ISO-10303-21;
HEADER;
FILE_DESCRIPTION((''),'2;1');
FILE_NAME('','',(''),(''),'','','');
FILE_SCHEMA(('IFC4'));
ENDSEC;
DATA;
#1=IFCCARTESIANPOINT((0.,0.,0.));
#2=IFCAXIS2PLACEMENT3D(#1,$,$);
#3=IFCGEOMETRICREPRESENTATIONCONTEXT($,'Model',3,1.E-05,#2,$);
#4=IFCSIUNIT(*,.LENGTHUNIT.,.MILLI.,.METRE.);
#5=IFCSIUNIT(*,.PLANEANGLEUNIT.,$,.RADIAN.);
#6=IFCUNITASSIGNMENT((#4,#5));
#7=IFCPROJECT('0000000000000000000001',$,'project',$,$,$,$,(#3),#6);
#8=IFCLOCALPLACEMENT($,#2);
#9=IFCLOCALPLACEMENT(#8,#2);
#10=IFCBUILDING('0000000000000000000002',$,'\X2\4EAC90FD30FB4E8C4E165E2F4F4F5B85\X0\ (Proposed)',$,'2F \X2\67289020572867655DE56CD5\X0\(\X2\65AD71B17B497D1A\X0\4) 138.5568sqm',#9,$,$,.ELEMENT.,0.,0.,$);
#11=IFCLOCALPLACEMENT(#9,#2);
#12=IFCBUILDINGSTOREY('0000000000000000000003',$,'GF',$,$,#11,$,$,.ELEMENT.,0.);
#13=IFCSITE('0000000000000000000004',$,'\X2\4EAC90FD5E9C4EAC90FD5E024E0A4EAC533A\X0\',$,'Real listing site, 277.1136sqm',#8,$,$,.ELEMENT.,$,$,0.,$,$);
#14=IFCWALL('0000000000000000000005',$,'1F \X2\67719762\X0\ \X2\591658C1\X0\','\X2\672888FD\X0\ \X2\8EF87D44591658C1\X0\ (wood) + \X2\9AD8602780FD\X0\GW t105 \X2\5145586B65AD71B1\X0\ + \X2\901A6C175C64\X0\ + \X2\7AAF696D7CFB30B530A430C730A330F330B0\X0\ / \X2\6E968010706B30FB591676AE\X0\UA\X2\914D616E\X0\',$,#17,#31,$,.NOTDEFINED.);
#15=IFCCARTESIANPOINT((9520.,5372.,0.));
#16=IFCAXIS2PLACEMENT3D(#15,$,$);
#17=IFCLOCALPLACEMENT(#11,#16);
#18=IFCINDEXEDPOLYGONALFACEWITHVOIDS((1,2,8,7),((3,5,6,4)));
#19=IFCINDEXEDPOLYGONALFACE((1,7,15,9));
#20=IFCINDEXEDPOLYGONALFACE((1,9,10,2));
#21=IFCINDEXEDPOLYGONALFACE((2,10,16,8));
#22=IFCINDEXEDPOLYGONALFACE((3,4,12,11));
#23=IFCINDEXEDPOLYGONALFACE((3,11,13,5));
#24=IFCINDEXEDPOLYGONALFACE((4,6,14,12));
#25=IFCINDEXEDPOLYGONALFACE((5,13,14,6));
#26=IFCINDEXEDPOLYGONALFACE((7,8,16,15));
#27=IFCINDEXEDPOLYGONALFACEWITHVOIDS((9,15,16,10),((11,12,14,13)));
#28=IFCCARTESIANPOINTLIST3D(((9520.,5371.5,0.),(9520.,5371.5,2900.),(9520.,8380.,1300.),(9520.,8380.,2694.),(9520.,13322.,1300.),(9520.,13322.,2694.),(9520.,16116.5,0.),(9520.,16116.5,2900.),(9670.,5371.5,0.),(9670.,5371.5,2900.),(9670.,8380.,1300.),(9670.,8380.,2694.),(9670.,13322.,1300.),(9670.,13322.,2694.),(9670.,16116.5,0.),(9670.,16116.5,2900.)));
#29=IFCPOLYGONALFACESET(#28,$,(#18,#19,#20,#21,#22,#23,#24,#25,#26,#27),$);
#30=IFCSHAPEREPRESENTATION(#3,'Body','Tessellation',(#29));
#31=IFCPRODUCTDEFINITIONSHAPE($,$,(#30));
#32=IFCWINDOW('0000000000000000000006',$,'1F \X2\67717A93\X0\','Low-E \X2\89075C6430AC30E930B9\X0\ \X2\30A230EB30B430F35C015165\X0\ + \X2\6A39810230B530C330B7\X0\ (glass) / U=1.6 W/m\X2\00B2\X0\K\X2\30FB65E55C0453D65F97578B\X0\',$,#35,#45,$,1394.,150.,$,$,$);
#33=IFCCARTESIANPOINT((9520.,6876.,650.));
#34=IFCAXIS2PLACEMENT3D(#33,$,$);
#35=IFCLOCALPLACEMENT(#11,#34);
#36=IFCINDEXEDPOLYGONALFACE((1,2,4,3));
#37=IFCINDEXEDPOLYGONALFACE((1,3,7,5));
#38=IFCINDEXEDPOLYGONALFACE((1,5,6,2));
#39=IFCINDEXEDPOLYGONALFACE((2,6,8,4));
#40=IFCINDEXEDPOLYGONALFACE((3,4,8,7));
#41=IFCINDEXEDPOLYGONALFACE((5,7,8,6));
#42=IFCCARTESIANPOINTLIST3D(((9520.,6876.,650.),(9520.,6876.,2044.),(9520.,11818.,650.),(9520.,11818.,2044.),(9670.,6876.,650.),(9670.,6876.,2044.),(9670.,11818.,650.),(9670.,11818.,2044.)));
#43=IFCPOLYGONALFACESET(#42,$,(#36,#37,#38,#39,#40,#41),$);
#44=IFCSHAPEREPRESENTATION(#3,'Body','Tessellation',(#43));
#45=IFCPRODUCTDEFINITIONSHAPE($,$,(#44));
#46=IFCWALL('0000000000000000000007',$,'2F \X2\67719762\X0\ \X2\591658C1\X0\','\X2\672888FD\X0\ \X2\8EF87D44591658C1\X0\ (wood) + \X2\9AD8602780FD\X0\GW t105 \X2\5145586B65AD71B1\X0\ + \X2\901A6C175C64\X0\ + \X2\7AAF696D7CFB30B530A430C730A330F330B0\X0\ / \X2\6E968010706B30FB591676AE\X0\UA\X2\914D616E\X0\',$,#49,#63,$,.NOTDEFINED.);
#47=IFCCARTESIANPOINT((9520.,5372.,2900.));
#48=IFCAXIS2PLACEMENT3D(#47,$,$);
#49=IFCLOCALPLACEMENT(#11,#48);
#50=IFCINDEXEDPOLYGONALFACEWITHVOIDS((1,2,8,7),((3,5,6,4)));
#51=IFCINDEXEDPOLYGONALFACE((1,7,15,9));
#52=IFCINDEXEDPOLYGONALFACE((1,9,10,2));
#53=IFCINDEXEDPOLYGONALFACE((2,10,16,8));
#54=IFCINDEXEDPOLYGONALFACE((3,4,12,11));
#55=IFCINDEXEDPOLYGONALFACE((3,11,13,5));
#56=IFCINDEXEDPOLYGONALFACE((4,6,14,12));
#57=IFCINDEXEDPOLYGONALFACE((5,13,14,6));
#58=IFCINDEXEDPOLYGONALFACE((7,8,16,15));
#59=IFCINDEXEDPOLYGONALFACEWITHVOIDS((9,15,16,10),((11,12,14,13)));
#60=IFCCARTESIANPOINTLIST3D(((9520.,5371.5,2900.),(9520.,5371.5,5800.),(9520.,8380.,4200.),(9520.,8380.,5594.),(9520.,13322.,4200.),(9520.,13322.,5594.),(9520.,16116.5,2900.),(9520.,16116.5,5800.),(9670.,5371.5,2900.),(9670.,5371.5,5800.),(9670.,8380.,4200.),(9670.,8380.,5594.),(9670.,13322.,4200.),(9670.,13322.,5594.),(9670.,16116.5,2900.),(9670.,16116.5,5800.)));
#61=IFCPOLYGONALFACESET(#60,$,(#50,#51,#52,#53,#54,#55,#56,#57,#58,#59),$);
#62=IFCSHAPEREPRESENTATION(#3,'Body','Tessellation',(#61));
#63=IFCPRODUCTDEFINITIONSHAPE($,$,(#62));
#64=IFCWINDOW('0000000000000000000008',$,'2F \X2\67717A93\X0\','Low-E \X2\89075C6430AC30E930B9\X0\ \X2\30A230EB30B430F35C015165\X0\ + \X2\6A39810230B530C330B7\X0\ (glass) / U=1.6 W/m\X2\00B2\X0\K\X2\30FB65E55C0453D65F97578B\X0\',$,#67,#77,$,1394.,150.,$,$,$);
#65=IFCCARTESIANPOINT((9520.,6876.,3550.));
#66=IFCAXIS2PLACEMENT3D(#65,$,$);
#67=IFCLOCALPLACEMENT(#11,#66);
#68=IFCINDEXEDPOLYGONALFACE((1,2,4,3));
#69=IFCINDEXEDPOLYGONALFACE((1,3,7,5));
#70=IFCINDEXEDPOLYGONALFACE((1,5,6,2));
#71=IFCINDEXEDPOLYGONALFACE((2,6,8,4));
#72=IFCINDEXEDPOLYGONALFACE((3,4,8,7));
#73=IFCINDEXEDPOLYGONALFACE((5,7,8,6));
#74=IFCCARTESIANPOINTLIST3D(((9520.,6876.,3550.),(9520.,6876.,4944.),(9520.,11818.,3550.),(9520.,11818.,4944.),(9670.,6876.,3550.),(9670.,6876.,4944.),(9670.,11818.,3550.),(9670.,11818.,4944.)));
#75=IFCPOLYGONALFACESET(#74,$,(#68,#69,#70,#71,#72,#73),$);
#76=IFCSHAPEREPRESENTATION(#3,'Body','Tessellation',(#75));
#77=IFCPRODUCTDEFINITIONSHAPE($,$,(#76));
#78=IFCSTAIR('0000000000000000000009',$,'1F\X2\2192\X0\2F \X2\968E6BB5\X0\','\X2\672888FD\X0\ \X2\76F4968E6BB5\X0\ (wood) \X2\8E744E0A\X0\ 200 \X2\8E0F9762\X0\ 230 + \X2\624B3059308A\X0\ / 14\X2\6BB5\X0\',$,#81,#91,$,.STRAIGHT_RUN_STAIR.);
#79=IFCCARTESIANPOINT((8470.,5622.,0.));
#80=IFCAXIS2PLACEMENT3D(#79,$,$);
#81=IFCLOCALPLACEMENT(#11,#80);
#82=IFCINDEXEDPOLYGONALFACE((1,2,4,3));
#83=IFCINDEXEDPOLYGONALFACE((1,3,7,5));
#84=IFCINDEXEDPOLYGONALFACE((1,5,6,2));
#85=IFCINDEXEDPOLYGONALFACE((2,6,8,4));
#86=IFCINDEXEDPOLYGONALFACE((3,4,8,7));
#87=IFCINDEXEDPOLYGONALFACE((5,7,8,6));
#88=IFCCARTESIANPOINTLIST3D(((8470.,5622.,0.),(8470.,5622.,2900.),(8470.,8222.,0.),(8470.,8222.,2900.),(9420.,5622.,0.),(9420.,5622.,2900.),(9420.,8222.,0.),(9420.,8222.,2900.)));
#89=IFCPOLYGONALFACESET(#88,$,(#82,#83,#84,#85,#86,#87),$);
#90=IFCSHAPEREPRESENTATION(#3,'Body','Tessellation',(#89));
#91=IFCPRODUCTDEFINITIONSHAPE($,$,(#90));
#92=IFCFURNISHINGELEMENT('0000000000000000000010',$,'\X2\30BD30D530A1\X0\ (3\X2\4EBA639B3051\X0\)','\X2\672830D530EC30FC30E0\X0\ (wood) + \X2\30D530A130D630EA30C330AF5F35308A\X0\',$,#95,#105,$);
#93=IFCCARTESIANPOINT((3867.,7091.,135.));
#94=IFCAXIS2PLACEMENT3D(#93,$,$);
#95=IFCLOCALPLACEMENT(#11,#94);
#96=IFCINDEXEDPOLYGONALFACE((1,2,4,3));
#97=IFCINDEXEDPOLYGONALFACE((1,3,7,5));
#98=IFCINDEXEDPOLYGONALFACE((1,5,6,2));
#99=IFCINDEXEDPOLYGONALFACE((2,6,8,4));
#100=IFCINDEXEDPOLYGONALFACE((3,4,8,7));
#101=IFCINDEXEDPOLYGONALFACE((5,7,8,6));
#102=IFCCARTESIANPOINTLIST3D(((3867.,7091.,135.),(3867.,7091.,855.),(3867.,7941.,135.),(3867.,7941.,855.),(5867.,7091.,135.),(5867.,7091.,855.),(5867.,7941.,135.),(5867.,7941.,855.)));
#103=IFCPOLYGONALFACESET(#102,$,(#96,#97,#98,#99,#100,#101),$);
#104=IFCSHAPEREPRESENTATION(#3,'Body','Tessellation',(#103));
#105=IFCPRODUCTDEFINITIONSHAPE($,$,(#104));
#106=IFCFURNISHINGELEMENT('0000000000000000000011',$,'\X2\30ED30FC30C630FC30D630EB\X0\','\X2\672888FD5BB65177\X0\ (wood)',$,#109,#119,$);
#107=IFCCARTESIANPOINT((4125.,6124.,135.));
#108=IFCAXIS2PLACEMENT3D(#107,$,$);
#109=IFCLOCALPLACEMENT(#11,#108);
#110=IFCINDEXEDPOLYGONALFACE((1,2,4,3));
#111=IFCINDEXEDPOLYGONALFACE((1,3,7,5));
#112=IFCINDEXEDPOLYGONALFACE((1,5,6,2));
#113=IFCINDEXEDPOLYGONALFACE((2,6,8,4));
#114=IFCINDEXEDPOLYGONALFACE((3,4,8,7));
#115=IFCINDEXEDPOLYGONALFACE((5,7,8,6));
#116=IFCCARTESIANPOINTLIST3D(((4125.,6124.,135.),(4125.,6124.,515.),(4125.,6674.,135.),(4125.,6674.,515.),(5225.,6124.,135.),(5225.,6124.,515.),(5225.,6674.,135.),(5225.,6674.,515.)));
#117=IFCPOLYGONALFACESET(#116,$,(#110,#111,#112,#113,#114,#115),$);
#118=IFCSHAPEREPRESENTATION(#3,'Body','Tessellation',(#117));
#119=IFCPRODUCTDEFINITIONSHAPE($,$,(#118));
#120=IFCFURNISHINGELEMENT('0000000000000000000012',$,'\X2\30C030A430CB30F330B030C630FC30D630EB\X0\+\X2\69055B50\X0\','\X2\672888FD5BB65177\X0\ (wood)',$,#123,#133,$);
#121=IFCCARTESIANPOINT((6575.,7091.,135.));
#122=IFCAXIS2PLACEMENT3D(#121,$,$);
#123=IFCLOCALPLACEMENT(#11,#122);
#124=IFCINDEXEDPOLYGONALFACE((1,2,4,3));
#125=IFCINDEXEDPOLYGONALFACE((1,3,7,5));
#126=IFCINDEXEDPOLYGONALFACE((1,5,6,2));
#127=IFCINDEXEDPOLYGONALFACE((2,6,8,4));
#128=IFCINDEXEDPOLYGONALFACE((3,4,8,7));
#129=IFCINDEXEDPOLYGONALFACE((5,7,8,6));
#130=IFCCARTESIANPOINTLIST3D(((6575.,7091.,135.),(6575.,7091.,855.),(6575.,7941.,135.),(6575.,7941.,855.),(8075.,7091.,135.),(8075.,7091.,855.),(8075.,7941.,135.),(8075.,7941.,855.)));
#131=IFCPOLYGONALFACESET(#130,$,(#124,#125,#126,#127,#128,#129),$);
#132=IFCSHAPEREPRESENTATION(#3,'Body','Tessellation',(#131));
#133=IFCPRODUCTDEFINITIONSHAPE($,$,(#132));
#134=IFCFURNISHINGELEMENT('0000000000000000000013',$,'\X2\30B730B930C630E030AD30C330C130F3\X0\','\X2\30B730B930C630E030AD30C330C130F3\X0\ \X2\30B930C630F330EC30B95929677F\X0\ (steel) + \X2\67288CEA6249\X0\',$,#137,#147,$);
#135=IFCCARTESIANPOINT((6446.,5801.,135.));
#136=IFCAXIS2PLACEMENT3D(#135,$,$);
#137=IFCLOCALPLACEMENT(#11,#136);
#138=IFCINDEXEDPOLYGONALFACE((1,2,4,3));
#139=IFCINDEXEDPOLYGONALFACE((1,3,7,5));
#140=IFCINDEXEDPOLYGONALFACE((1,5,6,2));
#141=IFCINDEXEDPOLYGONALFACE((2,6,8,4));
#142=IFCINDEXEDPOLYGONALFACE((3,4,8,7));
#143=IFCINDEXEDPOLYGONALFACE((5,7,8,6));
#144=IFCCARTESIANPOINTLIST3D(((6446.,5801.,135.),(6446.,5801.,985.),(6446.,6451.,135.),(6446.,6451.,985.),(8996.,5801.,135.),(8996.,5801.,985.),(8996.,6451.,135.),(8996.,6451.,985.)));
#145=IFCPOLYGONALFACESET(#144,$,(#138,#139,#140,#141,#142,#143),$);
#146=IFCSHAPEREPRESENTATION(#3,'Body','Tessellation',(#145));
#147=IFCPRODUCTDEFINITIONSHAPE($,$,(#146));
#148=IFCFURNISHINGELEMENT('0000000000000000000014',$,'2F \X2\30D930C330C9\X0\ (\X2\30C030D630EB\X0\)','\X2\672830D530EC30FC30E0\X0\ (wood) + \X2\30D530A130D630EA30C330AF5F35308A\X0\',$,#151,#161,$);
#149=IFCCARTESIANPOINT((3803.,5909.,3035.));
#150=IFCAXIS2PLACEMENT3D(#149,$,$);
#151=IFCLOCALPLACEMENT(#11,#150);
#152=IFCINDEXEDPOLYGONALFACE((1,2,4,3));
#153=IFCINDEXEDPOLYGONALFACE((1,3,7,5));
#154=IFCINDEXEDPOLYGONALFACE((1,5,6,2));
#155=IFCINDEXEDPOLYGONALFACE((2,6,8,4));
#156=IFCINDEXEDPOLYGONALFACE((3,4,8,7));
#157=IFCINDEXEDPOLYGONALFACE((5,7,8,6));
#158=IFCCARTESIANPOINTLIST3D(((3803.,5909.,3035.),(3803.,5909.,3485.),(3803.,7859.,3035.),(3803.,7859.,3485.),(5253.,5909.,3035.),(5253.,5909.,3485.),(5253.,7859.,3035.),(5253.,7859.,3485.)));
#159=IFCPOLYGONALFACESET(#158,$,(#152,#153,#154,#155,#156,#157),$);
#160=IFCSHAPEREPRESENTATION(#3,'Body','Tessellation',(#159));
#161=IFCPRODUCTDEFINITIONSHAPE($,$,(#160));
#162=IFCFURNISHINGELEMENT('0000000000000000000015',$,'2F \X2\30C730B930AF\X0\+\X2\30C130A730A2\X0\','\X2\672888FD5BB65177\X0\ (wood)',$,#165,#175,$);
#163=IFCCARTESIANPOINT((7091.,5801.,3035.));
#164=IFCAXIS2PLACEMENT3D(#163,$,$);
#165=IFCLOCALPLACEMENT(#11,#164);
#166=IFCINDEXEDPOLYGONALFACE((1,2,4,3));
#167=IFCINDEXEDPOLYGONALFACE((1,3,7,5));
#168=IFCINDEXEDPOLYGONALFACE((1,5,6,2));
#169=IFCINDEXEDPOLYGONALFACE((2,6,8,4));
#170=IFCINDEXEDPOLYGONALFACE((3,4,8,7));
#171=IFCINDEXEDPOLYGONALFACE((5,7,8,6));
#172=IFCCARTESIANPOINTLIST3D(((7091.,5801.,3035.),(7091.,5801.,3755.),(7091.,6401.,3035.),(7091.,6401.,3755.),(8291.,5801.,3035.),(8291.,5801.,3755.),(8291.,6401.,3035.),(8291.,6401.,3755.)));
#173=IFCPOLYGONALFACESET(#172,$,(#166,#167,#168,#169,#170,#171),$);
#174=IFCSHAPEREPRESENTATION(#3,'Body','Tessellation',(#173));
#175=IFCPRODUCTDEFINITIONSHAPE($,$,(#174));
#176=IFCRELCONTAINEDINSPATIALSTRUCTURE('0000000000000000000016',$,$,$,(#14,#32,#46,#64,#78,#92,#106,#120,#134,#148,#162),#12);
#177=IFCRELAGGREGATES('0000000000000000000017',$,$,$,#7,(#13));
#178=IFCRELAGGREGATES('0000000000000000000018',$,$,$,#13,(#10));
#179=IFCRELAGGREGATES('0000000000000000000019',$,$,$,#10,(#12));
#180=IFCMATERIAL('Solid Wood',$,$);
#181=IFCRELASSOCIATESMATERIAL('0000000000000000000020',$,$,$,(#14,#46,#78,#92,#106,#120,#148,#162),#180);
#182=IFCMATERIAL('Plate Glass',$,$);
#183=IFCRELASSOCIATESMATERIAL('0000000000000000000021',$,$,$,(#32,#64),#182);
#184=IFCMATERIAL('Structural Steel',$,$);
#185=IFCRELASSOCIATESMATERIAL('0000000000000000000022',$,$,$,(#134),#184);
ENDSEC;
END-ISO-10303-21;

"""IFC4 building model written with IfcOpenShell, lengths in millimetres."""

from ifc_helpers import new_model, si_unit, frame, frame_2d, origin, place, context, project, spatial, rectangle, extrude, material, element, fill, save


model = new_model("IFC4")

# Units and contexts
model_context = context("Model", 3, precision=1e-05, world=origin())
ifc_project = project(units=[si_unit("LENGTHUNIT", "METRE", prefix="MILLI"), si_unit("PLANEANGLEUNIT", "RADIAN")], contexts=[model_context])

# Site, building, storey
site_placement = place(None, origin())
site = spatial("IfcSite", under=ifc_project, at=site_placement, Name="京都府京都市上京区", ObjectType="Real listing site, 277.1136sqm", CompositionType="ELEMENT", RefElevation=0.0)
building_placement = place(site_placement, origin())
building = spatial("IfcBuilding", under=site, at=building_placement, Name="京都・二世帯住宅 (Proposed)", ObjectType="2F 木造在来工法(断熱等級4) 138.5568sqm", CompositionType="ELEMENT", ElevationOfRefHeight=0.0, ElevationOfTerrain=0.0)
storey_placement = place(building_placement, origin())
storey = spatial("IfcBuildingStorey", under=building, at=storey_placement, Name="GF", CompositionType="ELEMENT", Elevation=0.0)

# Wall, opening, window
ifc_material_1 = material(Name="Solid Wood")
wall_1_placement = place(storey_placement, frame((9520.0, 5372.0, 0.0)))
wall_1 = element("IfcWall", 1, at=wall_1_placement, inside=storey, material=ifc_material_1, Name="1F 東面 外壁", Description="木製 軸組外壁 (wood) + 高性能GW t105 充填断熱 + 通気層 + 窯業系サイディング / 準耐火・外皮UA配慮", PredefinedType="NOTDEFINED", context=model_context, shape_type="SweptSolid", body=[
    extrude(rectangle(XDim=150.0, YDim=10745.0, at=frame_2d((75.0, 5372.0))), frame((9520.0, 5372.0, 0.0)), (0.0, 0.0, 1.0), 2900.0),
])
opening_1_placement = place(storey_placement, frame((9520.0, 6876.0, 650.0)))
opening_1 = element("IfcOpeningElement", 2, at=opening_1_placement, cuts=wall_1, PredefinedType="NOTDEFINED", context=model_context, shape_type="SweptSolid", body=[
    extrude(rectangle(XDim=150.0, YDim=4942.0, at=frame_2d((75.0, 2471.0))), frame((9520.0, 6876.0, 650.0)), (0.0, 0.0, 1.0), 1394.0),
])
ifc_material_2 = material(Name="Plate Glass")
window_1_placement = place(storey_placement, frame((9520.0, 6876.0, 650.0)))
window_1 = element("IfcWindow", 3, at=window_1_placement, inside=storey, material=ifc_material_2, Name="1F 東窓", Description="Low-E 複層ガラス アルゴン封入 + 樹脂サッシ (glass) / U=1.6 W/m²K・日射取得型", OverallHeight=1394.0, OverallWidth=150.0, context=model_context, shape_type="SweptSolid", body=[
    extrude(rectangle(XDim=150.0, YDim=4942.0, at=frame_2d((75.0, 2471.0))), frame((9520.0, 6876.0, 650.0)), (0.0, 0.0, 1.0), 1394.0),
])
fill(opening_1, window_1)

# Wall, opening, window
wall_2_placement = place(storey_placement, frame((9520.0, 5372.0, 2900.0)))
wall_2 = element("IfcWall", 4, at=wall_2_placement, inside=storey, material=ifc_material_1, Name="2F 東面 外壁", Description="木製 軸組外壁 (wood) + 高性能GW t105 充填断熱 + 通気層 + 窯業系サイディング / 準耐火・外皮UA配慮", PredefinedType="NOTDEFINED", context=model_context, shape_type="SweptSolid", body=[
    extrude(rectangle(XDim=150.0, YDim=10745.0, at=frame_2d((75.0, 5372.0))), frame((9520.0, 5372.0, 2900.0)), (0.0, 0.0, 1.0), 2900.0),
])
opening_2_placement = place(storey_placement, frame((9520.0, 6876.0, 3550.0)))
opening_2 = element("IfcOpeningElement", 5, at=opening_2_placement, cuts=wall_2, PredefinedType="NOTDEFINED", context=model_context, shape_type="SweptSolid", body=[
    extrude(rectangle(XDim=150.0, YDim=4942.0, at=frame_2d((75.0, 2471.0))), frame((9520.0, 6876.0, 3550.0)), (0.0, 0.0, 1.0), 1394.0),
])
window_2_placement = place(storey_placement, frame((9520.0, 6876.0, 3550.0)))
window_2 = element("IfcWindow", 6, at=window_2_placement, inside=storey, material=ifc_material_2, Name="2F 東窓", Description="Low-E 複層ガラス アルゴン封入 + 樹脂サッシ (glass) / U=1.6 W/m²K・日射取得型", OverallHeight=1394.0, OverallWidth=150.0, context=model_context, shape_type="SweptSolid", body=[
    extrude(rectangle(XDim=150.0, YDim=4942.0, at=frame_2d((75.0, 2471.0))), frame((9520.0, 6876.0, 3550.0)), (0.0, 0.0, 1.0), 1394.0),
])
fill(opening_2, window_2)

# Stair
stair_placement = place(storey_placement, frame((8470.0, 5622.0, 0.0)))
element("IfcStair", 7, at=stair_placement, inside=storey, material=ifc_material_1, Name="1F→2F 階段", Description="木製 直階段 (wood) 蹴上 200 踏面 230 + 手すり / 14段", PredefinedType="STRAIGHT_RUN_STAIR", context=model_context, shape_type="SweptSolid", body=[
    extrude(rectangle(XDim=950.0, YDim=2600.0, at=frame_2d((475.0, 1300.0))), frame((8470.0, 5622.0, 0.0)), (0.0, 0.0, 1.0), 2900.0),
])

# Furnishing elements
furnishing_1_placement = place(storey_placement, frame((3867.0, 7091.0, 135.0)))
element("IfcFurnishingElement", 8, at=furnishing_1_placement, inside=storey, material=ifc_material_1, Name="ソファ (3人掛け)", Description="木フレーム (wood) + ファブリック張り", context=model_context, shape_type="SweptSolid", body=[
    extrude(rectangle(XDim=2000.0, YDim=850.0, at=frame_2d((1000.0, 425.0))), frame((3867.0, 7091.0, 135.0)), (0.0, 0.0, 1.0), 720.0),
])
furnishing_2_placement = place(storey_placement, frame((4125.0, 6124.0, 135.0)))
element("IfcFurnishingElement", 9, at=furnishing_2_placement, inside=storey, material=ifc_material_1, Name="ローテーブル", Description="木製家具 (wood)", context=model_context, shape_type="SweptSolid", body=[
    extrude(rectangle(XDim=1100.0, YDim=550.0, at=frame_2d((550.0, 275.0))), frame((4125.0, 6124.0, 135.0)), (0.0, 0.0, 1.0), 380.0),
])
furnishing_3_placement = place(storey_placement, frame((6575.0, 7091.0, 135.0)))
element("IfcFurnishingElement", 10, at=furnishing_3_placement, inside=storey, material=ifc_material_1, Name="ダイニングテーブル+椅子", Description="木製家具 (wood)", context=model_context, shape_type="SweptSolid", body=[
    extrude(rectangle(XDim=1500.0, YDim=850.0, at=frame_2d((750.0, 425.0))), frame((6575.0, 7091.0, 135.0)), (0.0, 0.0, 1.0), 720.0),
])
ifc_material_3 = material(Name="Structural Steel")
furnishing_4_placement = place(storey_placement, frame((6446.0, 5801.0, 135.0)))
element("IfcFurnishingElement", 11, at=furnishing_4_placement, inside=storey, material=ifc_material_3, Name="システムキッチン", Description="システムキッチン ステンレス天板 (steel) + 木質扉", context=model_context, shape_type="SweptSolid", body=[
    extrude(rectangle(XDim=2550.0, YDim=650.0, at=frame_2d((1275.0, 325.0))), frame((6446.0, 5801.0, 135.0)), (0.0, 0.0, 1.0), 850.0),
])
furnishing_5_placement = place(storey_placement, frame((3803.0, 5909.0, 3035.0)))
element("IfcFurnishingElement", 12, at=furnishing_5_placement, inside=storey, material=ifc_material_1, Name="2F ベッド (ダブル)", Description="木フレーム (wood) + ファブリック張り", context=model_context, shape_type="SweptSolid", body=[
    extrude(rectangle(XDim=1450.0, YDim=1950.0, at=frame_2d((725.0, 975.0))), frame((3803.0, 5909.0, 3035.0)), (0.0, 0.0, 1.0), 450.0),
])
furnishing_6_placement = place(storey_placement, frame((7091.0, 5801.0, 3035.0)))
element("IfcFurnishingElement", 13, at=furnishing_6_placement, inside=storey, material=ifc_material_1, Name="2F デスク+チェア", Description="木製家具 (wood)", context=model_context, shape_type="SweptSolid", body=[
    extrude(rectangle(XDim=1200.0, YDim=600.0, at=frame_2d((600.0, 300.0))), frame((7091.0, 5801.0, 3035.0)), (0.0, 0.0, 1.0), 720.0),
])

save(model, "model.ifc")
